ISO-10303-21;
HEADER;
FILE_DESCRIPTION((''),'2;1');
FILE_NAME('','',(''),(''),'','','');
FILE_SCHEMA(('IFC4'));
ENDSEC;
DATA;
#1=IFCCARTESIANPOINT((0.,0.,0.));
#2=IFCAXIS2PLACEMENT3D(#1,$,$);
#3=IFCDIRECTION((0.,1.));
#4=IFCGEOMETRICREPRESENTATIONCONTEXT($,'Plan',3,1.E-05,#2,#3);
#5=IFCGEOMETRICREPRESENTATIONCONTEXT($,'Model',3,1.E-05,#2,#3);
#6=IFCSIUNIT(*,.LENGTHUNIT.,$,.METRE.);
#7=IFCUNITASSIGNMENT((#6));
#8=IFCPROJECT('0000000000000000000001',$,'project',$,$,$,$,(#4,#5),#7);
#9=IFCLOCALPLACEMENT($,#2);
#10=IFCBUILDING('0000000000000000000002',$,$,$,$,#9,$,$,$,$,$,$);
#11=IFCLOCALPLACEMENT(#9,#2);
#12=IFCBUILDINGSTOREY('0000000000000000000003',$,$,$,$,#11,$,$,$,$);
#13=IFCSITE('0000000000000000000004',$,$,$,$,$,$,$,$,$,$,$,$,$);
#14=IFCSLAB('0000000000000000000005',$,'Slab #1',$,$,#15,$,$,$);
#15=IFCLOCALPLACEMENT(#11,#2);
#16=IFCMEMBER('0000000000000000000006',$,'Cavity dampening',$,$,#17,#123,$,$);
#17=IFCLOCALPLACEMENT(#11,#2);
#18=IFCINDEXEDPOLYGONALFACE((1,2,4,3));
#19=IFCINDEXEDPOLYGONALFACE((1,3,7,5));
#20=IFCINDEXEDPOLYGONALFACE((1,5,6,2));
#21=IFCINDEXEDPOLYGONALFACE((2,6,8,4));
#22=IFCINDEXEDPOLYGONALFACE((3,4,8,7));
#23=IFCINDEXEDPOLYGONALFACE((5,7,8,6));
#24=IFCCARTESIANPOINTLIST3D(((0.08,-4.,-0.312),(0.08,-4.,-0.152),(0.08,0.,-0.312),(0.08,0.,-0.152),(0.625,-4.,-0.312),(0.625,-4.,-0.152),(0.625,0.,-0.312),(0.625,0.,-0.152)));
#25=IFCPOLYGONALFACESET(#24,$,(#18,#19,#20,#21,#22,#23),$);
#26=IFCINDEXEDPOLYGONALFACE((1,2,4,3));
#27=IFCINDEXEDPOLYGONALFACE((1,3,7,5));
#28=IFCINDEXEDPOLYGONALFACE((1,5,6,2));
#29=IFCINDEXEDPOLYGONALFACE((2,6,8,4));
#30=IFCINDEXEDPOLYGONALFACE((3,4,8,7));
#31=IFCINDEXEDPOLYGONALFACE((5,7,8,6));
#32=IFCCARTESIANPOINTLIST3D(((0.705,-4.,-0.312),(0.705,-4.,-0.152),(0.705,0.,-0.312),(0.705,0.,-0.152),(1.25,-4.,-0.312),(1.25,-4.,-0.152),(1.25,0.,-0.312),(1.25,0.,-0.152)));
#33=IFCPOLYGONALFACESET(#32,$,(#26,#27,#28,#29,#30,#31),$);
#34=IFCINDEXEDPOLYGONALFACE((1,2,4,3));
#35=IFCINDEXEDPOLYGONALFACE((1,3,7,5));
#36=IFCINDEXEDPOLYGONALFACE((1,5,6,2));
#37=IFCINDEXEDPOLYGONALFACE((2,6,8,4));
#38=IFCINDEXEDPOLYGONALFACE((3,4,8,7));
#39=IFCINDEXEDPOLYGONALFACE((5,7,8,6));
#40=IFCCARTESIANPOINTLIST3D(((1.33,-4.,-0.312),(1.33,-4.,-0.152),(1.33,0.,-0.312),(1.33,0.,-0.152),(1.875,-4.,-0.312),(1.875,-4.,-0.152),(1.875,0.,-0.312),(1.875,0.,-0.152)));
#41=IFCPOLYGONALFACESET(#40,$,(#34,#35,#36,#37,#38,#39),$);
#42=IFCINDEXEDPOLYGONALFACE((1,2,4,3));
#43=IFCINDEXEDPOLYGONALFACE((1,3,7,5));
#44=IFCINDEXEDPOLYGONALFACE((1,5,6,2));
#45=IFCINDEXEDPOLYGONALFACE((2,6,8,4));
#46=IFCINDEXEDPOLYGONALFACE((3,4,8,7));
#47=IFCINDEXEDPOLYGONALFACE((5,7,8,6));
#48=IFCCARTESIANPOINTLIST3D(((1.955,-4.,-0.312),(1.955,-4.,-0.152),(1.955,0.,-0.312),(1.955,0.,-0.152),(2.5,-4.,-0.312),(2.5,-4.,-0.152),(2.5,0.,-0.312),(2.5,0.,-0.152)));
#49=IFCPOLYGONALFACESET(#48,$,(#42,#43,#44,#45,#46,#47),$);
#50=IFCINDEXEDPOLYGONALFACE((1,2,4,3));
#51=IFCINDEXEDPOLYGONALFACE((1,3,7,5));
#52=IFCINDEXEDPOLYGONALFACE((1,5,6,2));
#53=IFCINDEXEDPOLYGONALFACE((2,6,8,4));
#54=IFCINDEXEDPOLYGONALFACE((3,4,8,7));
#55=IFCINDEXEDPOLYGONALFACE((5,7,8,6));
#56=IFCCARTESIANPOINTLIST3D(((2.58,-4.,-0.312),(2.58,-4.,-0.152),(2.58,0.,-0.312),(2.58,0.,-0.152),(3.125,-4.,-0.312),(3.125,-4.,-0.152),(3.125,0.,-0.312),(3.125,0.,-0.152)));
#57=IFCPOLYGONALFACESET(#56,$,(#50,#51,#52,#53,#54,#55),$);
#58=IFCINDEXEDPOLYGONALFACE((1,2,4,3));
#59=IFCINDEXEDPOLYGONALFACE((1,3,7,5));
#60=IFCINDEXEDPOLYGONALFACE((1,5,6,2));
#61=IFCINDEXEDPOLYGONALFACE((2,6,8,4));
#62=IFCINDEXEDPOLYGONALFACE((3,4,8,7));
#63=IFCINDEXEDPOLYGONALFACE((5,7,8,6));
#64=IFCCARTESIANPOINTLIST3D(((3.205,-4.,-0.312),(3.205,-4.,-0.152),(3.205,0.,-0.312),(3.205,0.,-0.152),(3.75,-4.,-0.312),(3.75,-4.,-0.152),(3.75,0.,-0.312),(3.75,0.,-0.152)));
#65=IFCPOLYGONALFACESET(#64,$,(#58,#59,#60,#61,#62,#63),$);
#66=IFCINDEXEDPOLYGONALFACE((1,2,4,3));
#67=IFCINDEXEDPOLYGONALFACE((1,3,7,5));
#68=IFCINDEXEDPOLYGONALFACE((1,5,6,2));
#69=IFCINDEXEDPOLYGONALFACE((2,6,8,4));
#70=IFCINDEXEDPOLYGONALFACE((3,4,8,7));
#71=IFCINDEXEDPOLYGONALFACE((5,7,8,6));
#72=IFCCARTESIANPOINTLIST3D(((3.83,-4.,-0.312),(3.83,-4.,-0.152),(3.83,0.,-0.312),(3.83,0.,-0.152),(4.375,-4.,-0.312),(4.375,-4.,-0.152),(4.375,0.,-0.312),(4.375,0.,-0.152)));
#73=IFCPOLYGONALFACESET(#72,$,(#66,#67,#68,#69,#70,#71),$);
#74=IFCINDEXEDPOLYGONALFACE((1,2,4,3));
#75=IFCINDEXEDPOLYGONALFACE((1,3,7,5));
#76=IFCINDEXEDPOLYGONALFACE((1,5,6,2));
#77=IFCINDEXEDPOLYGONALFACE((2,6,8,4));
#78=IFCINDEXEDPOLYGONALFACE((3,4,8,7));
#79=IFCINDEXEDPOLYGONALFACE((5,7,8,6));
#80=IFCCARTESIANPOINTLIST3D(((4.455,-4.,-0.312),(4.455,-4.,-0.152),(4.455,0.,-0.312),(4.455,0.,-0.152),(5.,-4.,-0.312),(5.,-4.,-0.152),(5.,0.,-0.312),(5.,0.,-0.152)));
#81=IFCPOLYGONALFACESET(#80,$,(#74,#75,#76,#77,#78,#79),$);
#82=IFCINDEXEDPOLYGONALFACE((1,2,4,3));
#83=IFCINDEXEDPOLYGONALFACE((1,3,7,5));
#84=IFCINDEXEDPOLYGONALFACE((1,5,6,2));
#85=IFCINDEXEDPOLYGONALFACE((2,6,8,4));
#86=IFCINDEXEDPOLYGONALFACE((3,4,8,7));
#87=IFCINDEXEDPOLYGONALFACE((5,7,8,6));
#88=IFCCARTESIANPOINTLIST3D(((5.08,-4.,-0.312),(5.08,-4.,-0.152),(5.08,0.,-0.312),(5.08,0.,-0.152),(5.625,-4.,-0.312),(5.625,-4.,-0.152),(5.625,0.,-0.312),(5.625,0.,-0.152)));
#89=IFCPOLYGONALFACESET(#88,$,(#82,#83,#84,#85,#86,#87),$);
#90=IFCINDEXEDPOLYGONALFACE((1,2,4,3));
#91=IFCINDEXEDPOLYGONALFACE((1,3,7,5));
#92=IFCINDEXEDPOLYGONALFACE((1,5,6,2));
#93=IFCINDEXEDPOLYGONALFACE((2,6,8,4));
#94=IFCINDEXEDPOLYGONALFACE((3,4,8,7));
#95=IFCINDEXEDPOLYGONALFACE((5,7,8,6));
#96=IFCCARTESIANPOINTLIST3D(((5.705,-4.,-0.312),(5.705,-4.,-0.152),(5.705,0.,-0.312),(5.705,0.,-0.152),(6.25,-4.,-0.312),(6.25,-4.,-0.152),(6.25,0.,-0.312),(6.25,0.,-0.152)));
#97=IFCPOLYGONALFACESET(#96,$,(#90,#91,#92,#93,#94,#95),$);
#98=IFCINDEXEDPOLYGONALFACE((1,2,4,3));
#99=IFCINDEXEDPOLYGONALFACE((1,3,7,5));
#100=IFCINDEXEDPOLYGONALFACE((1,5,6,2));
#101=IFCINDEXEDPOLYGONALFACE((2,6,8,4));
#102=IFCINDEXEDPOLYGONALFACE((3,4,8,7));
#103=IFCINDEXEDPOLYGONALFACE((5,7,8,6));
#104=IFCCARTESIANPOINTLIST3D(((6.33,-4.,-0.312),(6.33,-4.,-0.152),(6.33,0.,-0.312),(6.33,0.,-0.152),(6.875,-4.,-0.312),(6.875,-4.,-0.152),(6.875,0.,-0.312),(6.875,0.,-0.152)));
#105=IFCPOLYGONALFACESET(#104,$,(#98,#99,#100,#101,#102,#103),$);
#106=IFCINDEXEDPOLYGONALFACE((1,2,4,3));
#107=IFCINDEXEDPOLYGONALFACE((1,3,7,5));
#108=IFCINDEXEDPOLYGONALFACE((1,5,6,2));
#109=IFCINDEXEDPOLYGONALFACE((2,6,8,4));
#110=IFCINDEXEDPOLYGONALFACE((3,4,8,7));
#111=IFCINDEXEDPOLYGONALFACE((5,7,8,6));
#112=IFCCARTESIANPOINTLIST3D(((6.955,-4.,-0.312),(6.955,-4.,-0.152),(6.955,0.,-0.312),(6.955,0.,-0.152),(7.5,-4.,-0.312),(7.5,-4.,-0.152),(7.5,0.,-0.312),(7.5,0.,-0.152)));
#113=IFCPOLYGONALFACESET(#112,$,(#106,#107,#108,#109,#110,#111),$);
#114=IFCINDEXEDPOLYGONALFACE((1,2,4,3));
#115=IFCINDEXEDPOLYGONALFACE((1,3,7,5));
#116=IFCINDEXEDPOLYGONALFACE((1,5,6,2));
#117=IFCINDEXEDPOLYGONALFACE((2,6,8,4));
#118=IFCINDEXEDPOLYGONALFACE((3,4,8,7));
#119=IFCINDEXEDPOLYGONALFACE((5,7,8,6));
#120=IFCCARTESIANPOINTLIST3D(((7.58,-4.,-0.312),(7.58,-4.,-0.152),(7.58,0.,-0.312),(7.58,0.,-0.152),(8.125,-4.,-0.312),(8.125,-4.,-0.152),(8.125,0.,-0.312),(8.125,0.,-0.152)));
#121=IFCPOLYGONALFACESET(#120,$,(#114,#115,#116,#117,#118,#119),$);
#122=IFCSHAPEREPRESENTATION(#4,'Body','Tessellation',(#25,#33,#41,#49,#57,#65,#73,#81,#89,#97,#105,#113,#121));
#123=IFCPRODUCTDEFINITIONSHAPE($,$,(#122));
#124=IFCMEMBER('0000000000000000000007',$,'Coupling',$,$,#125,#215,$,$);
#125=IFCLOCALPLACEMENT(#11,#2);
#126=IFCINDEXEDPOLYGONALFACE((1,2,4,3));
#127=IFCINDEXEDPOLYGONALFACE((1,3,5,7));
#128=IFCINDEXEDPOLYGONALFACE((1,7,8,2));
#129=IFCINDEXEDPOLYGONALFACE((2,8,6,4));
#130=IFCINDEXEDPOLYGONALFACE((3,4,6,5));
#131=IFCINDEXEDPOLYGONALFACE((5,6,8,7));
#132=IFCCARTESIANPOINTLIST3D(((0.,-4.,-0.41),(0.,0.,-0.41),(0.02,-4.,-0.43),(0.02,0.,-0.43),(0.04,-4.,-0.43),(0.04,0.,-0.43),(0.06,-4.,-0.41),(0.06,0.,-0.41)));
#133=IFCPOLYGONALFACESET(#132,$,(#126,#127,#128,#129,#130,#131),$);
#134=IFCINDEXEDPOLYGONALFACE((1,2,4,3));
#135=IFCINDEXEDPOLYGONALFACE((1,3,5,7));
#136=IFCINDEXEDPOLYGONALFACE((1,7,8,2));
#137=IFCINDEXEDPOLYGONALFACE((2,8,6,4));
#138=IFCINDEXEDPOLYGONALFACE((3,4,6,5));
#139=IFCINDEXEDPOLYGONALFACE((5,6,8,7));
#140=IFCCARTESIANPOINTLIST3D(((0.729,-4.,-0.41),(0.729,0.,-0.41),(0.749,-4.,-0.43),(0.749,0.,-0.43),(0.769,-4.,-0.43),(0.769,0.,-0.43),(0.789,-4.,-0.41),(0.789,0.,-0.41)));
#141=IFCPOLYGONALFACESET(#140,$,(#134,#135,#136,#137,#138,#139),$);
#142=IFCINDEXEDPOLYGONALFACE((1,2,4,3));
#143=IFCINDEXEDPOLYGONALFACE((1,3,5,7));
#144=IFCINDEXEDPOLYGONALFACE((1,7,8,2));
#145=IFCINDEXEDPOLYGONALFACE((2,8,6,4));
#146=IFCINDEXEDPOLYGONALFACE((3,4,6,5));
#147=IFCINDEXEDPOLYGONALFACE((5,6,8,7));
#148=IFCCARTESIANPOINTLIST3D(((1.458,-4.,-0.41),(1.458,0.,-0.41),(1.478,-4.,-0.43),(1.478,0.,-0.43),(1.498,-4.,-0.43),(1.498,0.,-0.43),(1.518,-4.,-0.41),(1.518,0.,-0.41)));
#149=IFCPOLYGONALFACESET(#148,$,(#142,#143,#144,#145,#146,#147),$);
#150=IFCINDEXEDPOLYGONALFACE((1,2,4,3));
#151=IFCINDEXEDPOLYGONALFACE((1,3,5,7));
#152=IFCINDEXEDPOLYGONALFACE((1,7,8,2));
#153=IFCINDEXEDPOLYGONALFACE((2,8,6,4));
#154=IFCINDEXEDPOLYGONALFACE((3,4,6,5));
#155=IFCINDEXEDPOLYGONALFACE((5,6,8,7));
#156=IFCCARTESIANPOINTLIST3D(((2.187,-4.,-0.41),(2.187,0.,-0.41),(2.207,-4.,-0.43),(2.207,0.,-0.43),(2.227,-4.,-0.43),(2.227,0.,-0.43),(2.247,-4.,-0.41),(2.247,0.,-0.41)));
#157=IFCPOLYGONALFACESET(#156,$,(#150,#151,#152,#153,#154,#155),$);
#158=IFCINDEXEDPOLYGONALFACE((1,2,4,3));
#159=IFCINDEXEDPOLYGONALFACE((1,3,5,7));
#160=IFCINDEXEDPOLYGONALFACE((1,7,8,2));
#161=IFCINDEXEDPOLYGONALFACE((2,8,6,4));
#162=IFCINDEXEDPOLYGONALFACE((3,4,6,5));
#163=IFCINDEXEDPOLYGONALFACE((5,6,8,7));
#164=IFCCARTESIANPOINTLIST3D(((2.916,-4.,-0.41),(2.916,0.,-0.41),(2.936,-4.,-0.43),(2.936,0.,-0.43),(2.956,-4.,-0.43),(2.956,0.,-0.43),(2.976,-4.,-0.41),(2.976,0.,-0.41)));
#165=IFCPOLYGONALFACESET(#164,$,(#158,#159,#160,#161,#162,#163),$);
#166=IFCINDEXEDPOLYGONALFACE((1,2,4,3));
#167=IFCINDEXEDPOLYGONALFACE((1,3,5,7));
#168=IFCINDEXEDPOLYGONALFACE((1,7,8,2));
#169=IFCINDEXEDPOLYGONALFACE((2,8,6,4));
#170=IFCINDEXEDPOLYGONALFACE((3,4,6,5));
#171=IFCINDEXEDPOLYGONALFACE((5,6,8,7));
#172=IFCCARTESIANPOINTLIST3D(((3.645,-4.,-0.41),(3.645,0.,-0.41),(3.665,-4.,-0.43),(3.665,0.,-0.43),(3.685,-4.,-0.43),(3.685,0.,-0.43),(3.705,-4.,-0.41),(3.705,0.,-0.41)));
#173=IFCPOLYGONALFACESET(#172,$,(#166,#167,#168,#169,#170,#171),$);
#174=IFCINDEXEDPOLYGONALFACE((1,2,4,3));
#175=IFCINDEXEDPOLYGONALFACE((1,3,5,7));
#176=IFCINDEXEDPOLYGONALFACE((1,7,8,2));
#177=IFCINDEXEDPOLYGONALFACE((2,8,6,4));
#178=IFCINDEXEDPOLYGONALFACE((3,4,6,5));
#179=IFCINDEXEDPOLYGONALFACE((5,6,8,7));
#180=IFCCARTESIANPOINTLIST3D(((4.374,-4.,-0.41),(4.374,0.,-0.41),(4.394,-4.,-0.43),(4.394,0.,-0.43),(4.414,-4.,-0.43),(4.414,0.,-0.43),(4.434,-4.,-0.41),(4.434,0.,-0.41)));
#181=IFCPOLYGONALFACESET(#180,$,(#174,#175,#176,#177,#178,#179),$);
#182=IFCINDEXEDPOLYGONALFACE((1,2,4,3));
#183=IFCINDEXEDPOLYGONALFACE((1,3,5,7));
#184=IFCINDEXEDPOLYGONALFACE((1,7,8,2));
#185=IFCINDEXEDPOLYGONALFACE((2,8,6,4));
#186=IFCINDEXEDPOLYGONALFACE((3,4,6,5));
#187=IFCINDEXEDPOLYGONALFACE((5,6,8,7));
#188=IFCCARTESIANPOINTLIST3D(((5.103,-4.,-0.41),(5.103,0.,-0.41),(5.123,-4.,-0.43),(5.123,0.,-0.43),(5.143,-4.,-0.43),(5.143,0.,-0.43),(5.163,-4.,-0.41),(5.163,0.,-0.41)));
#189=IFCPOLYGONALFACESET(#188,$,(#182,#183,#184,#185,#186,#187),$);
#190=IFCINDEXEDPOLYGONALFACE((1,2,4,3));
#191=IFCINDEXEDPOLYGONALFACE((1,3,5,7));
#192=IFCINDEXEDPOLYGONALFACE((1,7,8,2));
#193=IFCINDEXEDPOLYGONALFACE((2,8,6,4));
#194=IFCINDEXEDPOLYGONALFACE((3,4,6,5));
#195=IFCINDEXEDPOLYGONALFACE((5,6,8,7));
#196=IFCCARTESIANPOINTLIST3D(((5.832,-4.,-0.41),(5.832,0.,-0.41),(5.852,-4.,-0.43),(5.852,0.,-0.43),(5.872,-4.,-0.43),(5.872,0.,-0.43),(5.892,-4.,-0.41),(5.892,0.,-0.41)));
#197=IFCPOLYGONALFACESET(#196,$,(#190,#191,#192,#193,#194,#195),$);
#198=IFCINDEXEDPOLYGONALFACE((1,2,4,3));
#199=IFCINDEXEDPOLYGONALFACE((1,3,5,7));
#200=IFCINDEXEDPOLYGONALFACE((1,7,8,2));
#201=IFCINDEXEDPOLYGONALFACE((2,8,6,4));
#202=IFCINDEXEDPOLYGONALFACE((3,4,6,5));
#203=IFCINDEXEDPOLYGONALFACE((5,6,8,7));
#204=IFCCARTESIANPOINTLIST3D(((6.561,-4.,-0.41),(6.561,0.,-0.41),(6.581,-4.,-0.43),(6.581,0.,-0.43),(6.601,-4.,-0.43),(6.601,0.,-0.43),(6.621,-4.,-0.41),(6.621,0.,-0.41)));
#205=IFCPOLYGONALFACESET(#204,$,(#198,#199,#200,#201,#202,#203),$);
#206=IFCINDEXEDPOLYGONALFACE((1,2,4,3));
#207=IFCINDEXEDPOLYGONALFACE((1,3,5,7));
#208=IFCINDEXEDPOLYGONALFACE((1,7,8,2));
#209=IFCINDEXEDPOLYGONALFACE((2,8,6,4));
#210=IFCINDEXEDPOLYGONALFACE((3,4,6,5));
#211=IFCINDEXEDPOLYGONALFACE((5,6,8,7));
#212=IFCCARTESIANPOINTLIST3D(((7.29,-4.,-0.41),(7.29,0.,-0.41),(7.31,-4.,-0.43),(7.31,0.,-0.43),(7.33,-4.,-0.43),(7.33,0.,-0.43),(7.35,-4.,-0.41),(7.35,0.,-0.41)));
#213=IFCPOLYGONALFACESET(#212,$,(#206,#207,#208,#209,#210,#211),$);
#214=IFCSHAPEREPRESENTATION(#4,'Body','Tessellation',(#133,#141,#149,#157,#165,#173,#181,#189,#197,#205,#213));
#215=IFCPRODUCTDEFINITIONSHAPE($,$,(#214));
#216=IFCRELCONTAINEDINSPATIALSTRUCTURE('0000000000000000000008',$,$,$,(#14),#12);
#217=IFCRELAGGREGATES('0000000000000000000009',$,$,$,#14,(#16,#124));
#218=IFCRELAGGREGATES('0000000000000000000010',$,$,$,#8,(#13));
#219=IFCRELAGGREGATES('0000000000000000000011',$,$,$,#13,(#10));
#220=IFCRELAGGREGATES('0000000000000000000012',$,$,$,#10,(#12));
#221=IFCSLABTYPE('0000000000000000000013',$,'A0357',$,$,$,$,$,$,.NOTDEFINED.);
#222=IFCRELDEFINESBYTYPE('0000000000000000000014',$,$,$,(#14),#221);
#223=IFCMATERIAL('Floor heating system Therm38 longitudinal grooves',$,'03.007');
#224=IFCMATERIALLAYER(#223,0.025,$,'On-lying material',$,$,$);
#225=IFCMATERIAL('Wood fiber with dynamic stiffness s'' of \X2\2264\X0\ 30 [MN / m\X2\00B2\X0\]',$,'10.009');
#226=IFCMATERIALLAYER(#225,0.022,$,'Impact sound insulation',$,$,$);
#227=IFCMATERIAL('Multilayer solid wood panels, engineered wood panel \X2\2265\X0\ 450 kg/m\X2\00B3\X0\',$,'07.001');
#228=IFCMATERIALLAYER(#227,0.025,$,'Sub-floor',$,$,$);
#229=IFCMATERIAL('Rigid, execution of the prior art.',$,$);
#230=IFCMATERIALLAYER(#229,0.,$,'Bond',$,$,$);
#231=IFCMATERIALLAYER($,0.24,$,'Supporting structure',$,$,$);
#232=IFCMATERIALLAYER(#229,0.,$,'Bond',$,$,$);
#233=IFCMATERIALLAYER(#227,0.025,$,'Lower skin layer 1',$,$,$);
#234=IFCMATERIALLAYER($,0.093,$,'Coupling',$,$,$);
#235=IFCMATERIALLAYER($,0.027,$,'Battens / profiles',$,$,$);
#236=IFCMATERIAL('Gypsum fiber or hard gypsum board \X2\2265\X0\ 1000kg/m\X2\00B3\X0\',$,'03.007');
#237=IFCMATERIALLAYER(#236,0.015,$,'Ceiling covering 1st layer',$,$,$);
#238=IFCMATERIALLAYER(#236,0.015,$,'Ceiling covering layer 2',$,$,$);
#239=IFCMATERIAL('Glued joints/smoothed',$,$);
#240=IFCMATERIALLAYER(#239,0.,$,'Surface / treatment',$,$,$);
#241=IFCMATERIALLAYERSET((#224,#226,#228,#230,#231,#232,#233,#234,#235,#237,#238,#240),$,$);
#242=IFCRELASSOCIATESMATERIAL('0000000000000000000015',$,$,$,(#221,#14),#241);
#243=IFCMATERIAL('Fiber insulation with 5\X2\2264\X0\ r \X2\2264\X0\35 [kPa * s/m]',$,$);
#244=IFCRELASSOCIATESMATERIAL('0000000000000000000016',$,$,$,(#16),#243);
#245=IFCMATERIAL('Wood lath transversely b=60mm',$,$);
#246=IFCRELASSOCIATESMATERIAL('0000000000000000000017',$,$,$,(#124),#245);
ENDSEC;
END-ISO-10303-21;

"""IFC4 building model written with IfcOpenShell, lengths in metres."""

from ifc_helpers import new_model, si_unit, direction, frame, frame_2d, origin, place, context, project, spatial, polyline, rectangle, outline, extrude, material, layer, layer_set, type_object, element, aggregate, save


model = new_model("IFC4")

# Units and contexts
plan_context = context("Plan", 3, precision=1e-05, world=origin(), true_north=direction((0.0, 1.0)))
model_context = context("Model", 3, precision=1e-05, world=origin(), true_north=direction((0.0, 1.0)))
ifc_project = project(units=[si_unit("LENGTHUNIT", "METRE")], contexts=[plan_context, model_context])

# Site, building, storey
site = spatial("IfcSite", under=ifc_project)
building_placement = place(None, origin())
building = spatial("IfcBuilding", under=site, at=building_placement)
storey_placement = place(building_placement, origin())
storey = spatial("IfcBuildingStorey", under=building, at=storey_placement)

# Slab, members
ifc_material_1 = material(Name="Floor heating system Therm38 longitudinal grooves", Category="03.007")
ifc_layer_1 = layer(ifc_material_1, 0.025, Name="On-lying material")
ifc_material_2 = material(Name="Wood fiber with dynamic stiffness s' of ≤ 30 [MN / m²]", Category="10.009")
ifc_layer_2 = layer(ifc_material_2, 0.022, Name="Impact sound insulation")
ifc_material_3 = material(Name="Multilayer solid wood panels, engineered wood panel ≥ 450 kg/m³", Category="07.001")
ifc_layer_3 = layer(ifc_material_3, 0.025, Name="Sub-floor")
ifc_material_4 = material(Name="Rigid, execution of the prior art.")
ifc_layer_4 = layer(ifc_material_4, 0.0, Name="Bond")
ifc_layer_5 = layer(None, 0.24, Name="Supporting structure")
ifc_layer_6 = layer(ifc_material_4, 0.0, Name="Bond")
ifc_layer_7 = layer(ifc_material_3, 0.025, Name="Lower skin layer 1")
ifc_layer_8 = layer(None, 0.093, Name="Coupling")
ifc_layer_9 = layer(None, 0.027, Name="Battens / profiles")
ifc_material_5 = material(Name="Gypsum fiber or hard gypsum board ≥ 1000kg/m³", Category="03.007")
ifc_layer_10 = layer(ifc_material_5, 0.015, Name="Ceiling covering 1st layer")
ifc_layer_11 = layer(ifc_material_5, 0.015, Name="Ceiling covering layer 2")
ifc_material_6 = material(Name="Glued joints/smoothed")
ifc_layer_12 = layer(ifc_material_6, 0.0, Name="Surface / treatment")
ifc_layer_set = layer_set([ifc_layer_1, ifc_layer_2, ifc_layer_3, ifc_layer_4, ifc_layer_5, ifc_layer_6, ifc_layer_7, ifc_layer_8, ifc_layer_9, ifc_layer_10, ifc_layer_11, ifc_layer_12])
slab_type = type_object("IfcSlabType", Name="A0357", PredefinedType="NOTDEFINED", material=ifc_layer_set)
slab_placement = place(None, frame((0.0, 0.0, 0.0), z_axis=(0.0, 0.0, -1.0), x_axis=(1.0, 0.0, 0.0)))
slab = element("IfcSlab", 1, at=slab_placement, inside=storey, type_object=slab_type, material=ifc_layer_set, Name="Slab #1")
ifc_material_7 = material(Name="Fiber insulation with 5≤ r ≤35 [kPa * s/m]")
member_1_placement = place(slab_placement, origin())
member_1 = element("IfcMember", 2, at=member_1_placement, material=ifc_material_7, Name="Cavity dampening", context=plan_context, shape_type="SweptSolid", body=[
    extrude(rectangle(XDim=0.545, YDim=0.16, at=frame_2d((0.2725, 0.08), x_axis=(1.0, 0.0))), frame((0.08, 4.0, 0.152), z_axis=(0.0, -1.0, 0.0), x_axis=(1.0, 0.0, 0.0)), (0.0, 0.0, 1.0), 4.0),
    extrude(rectangle(XDim=0.545, YDim=0.16, at=frame_2d((0.2725, 0.08), x_axis=(1.0, 0.0))), frame((0.705, 4.0, 0.152), z_axis=(0.0, -1.0, 0.0), x_axis=(1.0, 0.0, 0.0)), (0.0, 0.0, 1.0), 4.0),
    extrude(rectangle(XDim=0.545, YDim=0.16, at=frame_2d((0.2725, 0.08), x_axis=(1.0, 0.0))), frame((1.33, 4.0, 0.152), z_axis=(0.0, -1.0, 0.0), x_axis=(1.0, 0.0, 0.0)), (0.0, 0.0, 1.0), 4.0),
    extrude(rectangle(XDim=0.545, YDim=0.16, at=frame_2d((0.2725, 0.08), x_axis=(1.0, 0.0))), frame((1.955, 4.0, 0.152), z_axis=(0.0, -1.0, 0.0), x_axis=(1.0, 0.0, 0.0)), (0.0, 0.0, 1.0), 4.0),
    extrude(rectangle(XDim=0.545, YDim=0.16, at=frame_2d((0.2725, 0.08), x_axis=(1.0, 0.0))), frame((2.58, 4.0, 0.152), z_axis=(0.0, -1.0, 0.0), x_axis=(1.0, 0.0, 0.0)), (0.0, 0.0, 1.0), 4.0),
    extrude(rectangle(XDim=0.545, YDim=0.16, at=frame_2d((0.2725, 0.08), x_axis=(1.0, 0.0))), frame((3.205, 4.0, 0.152), z_axis=(0.0, -1.0, 0.0), x_axis=(1.0, 0.0, 0.0)), (0.0, 0.0, 1.0), 4.0),
    extrude(rectangle(XDim=0.545, YDim=0.16, at=frame_2d((0.2725, 0.08), x_axis=(1.0, 0.0))), frame((3.83, 4.0, 0.152), z_axis=(0.0, -1.0, 0.0), x_axis=(1.0, 0.0, 0.0)), (0.0, 0.0, 1.0), 4.0),
    extrude(rectangle(XDim=0.545, YDim=0.16, at=frame_2d((0.2725, 0.08), x_axis=(1.0, 0.0))), frame((4.455, 4.0, 0.152), z_axis=(0.0, -1.0, 0.0), x_axis=(1.0, 0.0, 0.0)), (0.0, 0.0, 1.0), 4.0),
    extrude(rectangle(XDim=0.545, YDim=0.16, at=frame_2d((0.2725, 0.08), x_axis=(1.0, 0.0))), frame((5.08, 4.0, 0.152), z_axis=(0.0, -1.0, 0.0), x_axis=(1.0, 0.0, 0.0)), (0.0, 0.0, 1.0), 4.0),
    extrude(rectangle(XDim=0.545, YDim=0.16, at=frame_2d((0.2725, 0.08), x_axis=(1.0, 0.0))), frame((5.705, 4.0, 0.152), z_axis=(0.0, -1.0, 0.0), x_axis=(1.0, 0.0, 0.0)), (0.0, 0.0, 1.0), 4.0),
    extrude(rectangle(XDim=0.545, YDim=0.16, at=frame_2d((0.2725, 0.08), x_axis=(1.0, 0.0))), frame((6.33, 4.0, 0.152), z_axis=(0.0, -1.0, 0.0), x_axis=(1.0, 0.0, 0.0)), (0.0, 0.0, 1.0), 4.0),
    extrude(rectangle(XDim=0.545, YDim=0.16, at=frame_2d((0.2725, 0.08), x_axis=(1.0, 0.0))), frame((6.955, 4.0, 0.152), z_axis=(0.0, -1.0, 0.0), x_axis=(1.0, 0.0, 0.0)), (0.0, 0.0, 1.0), 4.0),
    extrude(rectangle(XDim=0.545, YDim=0.16, at=frame_2d((0.2725, 0.08), x_axis=(1.0, 0.0))), frame((7.58, 4.0, 0.152), z_axis=(0.0, -1.0, 0.0), x_axis=(1.0, 0.0, 0.0)), (0.0, 0.0, 1.0), 4.0),
])
ifc_material_8 = material(Name="Wood lath transversely b=60mm")
member_2_placement = place(slab_placement, origin())
member_2 = element("IfcMember", 3, at=member_2_placement, material=ifc_material_8, Name="Coupling", context=plan_context, shape_type="SweptSolid", body=[
    extrude(outline(polyline([(0.0, 0.0), (0.06, 0.0), (0.04, 0.02), (0.02, 0.02), (0.0, 0.0)])), frame((0.0, 4.0, 0.41), z_axis=(0.0, -1.0, 0.0), x_axis=(1.0, 0.0, 0.0)), (0.0, 0.0, 1.0), 4.0),
    extrude(outline(polyline([(0.0, 0.0), (0.06, 0.0), (0.04, 0.02), (0.02, 0.02), (0.0, 0.0)])), frame((0.729, 4.0, 0.41), z_axis=(0.0, -1.0, 0.0), x_axis=(1.0, 0.0, 0.0)), (0.0, 0.0, 1.0), 4.0),
    extrude(outline(polyline([(0.0, 0.0), (0.06, 0.0), (0.04, 0.02), (0.02, 0.02), (0.0, 0.0)])), frame((1.458, 4.0, 0.41), z_axis=(0.0, -1.0, 0.0), x_axis=(1.0, 0.0, 0.0)), (0.0, 0.0, 1.0), 4.0),
    extrude(outline(polyline([(0.0, 0.0), (0.06, 0.0), (0.04, 0.02), (0.02, 0.02), (0.0, 0.0)])), frame((2.187, 4.0, 0.41), z_axis=(0.0, -1.0, 0.0), x_axis=(1.0, 0.0, 0.0)), (0.0, 0.0, 1.0), 4.0),
    extrude(outline(polyline([(0.0, 0.0), (0.06, 0.0), (0.04, 0.02), (0.02, 0.02), (0.0, 0.0)])), frame((2.916, 4.0, 0.41), z_axis=(0.0, -1.0, 0.0), x_axis=(1.0, 0.0, 0.0)), (0.0, 0.0, 1.0), 4.0),
    extrude(outline(polyline([(0.0, 0.0), (0.06, 0.0), (0.04, 0.02), (0.02, 0.02), (0.0, 0.0)])), frame((3.645, 4.0, 0.41), z_axis=(0.0, -1.0, 0.0), x_axis=(1.0, 0.0, 0.0)), (0.0, 0.0, 1.0), 4.0),
    extrude(outline(polyline([(0.0, 0.0), (0.06, 0.0), (0.04, 0.02), (0.02, 0.02), (0.0, 0.0)])), frame((4.374, 4.0, 0.41), z_axis=(0.0, -1.0, 0.0), x_axis=(1.0, 0.0, 0.0)), (0.0, 0.0, 1.0), 4.0),
    extrude(outline(polyline([(0.0, 0.0), (0.06, 0.0), (0.04, 0.02), (0.02, 0.02), (0.0, 0.0)])), frame((5.103, 4.0, 0.41), z_axis=(0.0, -1.0, 0.0), x_axis=(1.0, 0.0, 0.0)), (0.0, 0.0, 1.0), 4.0),
    extrude(outline(polyline([(0.0, 0.0), (0.06, 0.0), (0.04, 0.02), (0.02, 0.02), (0.0, 0.0)])), frame((5.832, 4.0, 0.41), z_axis=(0.0, -1.0, 0.0), x_axis=(1.0, 0.0, 0.0)), (0.0, 0.0, 1.0), 4.0),
    extrude(outline(polyline([(0.0, 0.0), (0.06, 0.0), (0.04, 0.02), (0.02, 0.02), (0.0, 0.0)])), frame((6.561, 4.0, 0.41), z_axis=(0.0, -1.0, 0.0), x_axis=(1.0, 0.0, 0.0)), (0.0, 0.0, 1.0), 4.0),
    extrude(outline(polyline([(0.0, 0.0), (0.06, 0.0), (0.04, 0.02), (0.02, 0.02), (0.0, 0.0)])), frame((7.29, 4.0, 0.41), z_axis=(0.0, -1.0, 0.0), x_axis=(1.0, 0.0, 0.0)), (0.0, 0.0, 1.0), 4.0),
])
aggregate(slab, [member_1, member_2])

save(model, "model.ifc")
